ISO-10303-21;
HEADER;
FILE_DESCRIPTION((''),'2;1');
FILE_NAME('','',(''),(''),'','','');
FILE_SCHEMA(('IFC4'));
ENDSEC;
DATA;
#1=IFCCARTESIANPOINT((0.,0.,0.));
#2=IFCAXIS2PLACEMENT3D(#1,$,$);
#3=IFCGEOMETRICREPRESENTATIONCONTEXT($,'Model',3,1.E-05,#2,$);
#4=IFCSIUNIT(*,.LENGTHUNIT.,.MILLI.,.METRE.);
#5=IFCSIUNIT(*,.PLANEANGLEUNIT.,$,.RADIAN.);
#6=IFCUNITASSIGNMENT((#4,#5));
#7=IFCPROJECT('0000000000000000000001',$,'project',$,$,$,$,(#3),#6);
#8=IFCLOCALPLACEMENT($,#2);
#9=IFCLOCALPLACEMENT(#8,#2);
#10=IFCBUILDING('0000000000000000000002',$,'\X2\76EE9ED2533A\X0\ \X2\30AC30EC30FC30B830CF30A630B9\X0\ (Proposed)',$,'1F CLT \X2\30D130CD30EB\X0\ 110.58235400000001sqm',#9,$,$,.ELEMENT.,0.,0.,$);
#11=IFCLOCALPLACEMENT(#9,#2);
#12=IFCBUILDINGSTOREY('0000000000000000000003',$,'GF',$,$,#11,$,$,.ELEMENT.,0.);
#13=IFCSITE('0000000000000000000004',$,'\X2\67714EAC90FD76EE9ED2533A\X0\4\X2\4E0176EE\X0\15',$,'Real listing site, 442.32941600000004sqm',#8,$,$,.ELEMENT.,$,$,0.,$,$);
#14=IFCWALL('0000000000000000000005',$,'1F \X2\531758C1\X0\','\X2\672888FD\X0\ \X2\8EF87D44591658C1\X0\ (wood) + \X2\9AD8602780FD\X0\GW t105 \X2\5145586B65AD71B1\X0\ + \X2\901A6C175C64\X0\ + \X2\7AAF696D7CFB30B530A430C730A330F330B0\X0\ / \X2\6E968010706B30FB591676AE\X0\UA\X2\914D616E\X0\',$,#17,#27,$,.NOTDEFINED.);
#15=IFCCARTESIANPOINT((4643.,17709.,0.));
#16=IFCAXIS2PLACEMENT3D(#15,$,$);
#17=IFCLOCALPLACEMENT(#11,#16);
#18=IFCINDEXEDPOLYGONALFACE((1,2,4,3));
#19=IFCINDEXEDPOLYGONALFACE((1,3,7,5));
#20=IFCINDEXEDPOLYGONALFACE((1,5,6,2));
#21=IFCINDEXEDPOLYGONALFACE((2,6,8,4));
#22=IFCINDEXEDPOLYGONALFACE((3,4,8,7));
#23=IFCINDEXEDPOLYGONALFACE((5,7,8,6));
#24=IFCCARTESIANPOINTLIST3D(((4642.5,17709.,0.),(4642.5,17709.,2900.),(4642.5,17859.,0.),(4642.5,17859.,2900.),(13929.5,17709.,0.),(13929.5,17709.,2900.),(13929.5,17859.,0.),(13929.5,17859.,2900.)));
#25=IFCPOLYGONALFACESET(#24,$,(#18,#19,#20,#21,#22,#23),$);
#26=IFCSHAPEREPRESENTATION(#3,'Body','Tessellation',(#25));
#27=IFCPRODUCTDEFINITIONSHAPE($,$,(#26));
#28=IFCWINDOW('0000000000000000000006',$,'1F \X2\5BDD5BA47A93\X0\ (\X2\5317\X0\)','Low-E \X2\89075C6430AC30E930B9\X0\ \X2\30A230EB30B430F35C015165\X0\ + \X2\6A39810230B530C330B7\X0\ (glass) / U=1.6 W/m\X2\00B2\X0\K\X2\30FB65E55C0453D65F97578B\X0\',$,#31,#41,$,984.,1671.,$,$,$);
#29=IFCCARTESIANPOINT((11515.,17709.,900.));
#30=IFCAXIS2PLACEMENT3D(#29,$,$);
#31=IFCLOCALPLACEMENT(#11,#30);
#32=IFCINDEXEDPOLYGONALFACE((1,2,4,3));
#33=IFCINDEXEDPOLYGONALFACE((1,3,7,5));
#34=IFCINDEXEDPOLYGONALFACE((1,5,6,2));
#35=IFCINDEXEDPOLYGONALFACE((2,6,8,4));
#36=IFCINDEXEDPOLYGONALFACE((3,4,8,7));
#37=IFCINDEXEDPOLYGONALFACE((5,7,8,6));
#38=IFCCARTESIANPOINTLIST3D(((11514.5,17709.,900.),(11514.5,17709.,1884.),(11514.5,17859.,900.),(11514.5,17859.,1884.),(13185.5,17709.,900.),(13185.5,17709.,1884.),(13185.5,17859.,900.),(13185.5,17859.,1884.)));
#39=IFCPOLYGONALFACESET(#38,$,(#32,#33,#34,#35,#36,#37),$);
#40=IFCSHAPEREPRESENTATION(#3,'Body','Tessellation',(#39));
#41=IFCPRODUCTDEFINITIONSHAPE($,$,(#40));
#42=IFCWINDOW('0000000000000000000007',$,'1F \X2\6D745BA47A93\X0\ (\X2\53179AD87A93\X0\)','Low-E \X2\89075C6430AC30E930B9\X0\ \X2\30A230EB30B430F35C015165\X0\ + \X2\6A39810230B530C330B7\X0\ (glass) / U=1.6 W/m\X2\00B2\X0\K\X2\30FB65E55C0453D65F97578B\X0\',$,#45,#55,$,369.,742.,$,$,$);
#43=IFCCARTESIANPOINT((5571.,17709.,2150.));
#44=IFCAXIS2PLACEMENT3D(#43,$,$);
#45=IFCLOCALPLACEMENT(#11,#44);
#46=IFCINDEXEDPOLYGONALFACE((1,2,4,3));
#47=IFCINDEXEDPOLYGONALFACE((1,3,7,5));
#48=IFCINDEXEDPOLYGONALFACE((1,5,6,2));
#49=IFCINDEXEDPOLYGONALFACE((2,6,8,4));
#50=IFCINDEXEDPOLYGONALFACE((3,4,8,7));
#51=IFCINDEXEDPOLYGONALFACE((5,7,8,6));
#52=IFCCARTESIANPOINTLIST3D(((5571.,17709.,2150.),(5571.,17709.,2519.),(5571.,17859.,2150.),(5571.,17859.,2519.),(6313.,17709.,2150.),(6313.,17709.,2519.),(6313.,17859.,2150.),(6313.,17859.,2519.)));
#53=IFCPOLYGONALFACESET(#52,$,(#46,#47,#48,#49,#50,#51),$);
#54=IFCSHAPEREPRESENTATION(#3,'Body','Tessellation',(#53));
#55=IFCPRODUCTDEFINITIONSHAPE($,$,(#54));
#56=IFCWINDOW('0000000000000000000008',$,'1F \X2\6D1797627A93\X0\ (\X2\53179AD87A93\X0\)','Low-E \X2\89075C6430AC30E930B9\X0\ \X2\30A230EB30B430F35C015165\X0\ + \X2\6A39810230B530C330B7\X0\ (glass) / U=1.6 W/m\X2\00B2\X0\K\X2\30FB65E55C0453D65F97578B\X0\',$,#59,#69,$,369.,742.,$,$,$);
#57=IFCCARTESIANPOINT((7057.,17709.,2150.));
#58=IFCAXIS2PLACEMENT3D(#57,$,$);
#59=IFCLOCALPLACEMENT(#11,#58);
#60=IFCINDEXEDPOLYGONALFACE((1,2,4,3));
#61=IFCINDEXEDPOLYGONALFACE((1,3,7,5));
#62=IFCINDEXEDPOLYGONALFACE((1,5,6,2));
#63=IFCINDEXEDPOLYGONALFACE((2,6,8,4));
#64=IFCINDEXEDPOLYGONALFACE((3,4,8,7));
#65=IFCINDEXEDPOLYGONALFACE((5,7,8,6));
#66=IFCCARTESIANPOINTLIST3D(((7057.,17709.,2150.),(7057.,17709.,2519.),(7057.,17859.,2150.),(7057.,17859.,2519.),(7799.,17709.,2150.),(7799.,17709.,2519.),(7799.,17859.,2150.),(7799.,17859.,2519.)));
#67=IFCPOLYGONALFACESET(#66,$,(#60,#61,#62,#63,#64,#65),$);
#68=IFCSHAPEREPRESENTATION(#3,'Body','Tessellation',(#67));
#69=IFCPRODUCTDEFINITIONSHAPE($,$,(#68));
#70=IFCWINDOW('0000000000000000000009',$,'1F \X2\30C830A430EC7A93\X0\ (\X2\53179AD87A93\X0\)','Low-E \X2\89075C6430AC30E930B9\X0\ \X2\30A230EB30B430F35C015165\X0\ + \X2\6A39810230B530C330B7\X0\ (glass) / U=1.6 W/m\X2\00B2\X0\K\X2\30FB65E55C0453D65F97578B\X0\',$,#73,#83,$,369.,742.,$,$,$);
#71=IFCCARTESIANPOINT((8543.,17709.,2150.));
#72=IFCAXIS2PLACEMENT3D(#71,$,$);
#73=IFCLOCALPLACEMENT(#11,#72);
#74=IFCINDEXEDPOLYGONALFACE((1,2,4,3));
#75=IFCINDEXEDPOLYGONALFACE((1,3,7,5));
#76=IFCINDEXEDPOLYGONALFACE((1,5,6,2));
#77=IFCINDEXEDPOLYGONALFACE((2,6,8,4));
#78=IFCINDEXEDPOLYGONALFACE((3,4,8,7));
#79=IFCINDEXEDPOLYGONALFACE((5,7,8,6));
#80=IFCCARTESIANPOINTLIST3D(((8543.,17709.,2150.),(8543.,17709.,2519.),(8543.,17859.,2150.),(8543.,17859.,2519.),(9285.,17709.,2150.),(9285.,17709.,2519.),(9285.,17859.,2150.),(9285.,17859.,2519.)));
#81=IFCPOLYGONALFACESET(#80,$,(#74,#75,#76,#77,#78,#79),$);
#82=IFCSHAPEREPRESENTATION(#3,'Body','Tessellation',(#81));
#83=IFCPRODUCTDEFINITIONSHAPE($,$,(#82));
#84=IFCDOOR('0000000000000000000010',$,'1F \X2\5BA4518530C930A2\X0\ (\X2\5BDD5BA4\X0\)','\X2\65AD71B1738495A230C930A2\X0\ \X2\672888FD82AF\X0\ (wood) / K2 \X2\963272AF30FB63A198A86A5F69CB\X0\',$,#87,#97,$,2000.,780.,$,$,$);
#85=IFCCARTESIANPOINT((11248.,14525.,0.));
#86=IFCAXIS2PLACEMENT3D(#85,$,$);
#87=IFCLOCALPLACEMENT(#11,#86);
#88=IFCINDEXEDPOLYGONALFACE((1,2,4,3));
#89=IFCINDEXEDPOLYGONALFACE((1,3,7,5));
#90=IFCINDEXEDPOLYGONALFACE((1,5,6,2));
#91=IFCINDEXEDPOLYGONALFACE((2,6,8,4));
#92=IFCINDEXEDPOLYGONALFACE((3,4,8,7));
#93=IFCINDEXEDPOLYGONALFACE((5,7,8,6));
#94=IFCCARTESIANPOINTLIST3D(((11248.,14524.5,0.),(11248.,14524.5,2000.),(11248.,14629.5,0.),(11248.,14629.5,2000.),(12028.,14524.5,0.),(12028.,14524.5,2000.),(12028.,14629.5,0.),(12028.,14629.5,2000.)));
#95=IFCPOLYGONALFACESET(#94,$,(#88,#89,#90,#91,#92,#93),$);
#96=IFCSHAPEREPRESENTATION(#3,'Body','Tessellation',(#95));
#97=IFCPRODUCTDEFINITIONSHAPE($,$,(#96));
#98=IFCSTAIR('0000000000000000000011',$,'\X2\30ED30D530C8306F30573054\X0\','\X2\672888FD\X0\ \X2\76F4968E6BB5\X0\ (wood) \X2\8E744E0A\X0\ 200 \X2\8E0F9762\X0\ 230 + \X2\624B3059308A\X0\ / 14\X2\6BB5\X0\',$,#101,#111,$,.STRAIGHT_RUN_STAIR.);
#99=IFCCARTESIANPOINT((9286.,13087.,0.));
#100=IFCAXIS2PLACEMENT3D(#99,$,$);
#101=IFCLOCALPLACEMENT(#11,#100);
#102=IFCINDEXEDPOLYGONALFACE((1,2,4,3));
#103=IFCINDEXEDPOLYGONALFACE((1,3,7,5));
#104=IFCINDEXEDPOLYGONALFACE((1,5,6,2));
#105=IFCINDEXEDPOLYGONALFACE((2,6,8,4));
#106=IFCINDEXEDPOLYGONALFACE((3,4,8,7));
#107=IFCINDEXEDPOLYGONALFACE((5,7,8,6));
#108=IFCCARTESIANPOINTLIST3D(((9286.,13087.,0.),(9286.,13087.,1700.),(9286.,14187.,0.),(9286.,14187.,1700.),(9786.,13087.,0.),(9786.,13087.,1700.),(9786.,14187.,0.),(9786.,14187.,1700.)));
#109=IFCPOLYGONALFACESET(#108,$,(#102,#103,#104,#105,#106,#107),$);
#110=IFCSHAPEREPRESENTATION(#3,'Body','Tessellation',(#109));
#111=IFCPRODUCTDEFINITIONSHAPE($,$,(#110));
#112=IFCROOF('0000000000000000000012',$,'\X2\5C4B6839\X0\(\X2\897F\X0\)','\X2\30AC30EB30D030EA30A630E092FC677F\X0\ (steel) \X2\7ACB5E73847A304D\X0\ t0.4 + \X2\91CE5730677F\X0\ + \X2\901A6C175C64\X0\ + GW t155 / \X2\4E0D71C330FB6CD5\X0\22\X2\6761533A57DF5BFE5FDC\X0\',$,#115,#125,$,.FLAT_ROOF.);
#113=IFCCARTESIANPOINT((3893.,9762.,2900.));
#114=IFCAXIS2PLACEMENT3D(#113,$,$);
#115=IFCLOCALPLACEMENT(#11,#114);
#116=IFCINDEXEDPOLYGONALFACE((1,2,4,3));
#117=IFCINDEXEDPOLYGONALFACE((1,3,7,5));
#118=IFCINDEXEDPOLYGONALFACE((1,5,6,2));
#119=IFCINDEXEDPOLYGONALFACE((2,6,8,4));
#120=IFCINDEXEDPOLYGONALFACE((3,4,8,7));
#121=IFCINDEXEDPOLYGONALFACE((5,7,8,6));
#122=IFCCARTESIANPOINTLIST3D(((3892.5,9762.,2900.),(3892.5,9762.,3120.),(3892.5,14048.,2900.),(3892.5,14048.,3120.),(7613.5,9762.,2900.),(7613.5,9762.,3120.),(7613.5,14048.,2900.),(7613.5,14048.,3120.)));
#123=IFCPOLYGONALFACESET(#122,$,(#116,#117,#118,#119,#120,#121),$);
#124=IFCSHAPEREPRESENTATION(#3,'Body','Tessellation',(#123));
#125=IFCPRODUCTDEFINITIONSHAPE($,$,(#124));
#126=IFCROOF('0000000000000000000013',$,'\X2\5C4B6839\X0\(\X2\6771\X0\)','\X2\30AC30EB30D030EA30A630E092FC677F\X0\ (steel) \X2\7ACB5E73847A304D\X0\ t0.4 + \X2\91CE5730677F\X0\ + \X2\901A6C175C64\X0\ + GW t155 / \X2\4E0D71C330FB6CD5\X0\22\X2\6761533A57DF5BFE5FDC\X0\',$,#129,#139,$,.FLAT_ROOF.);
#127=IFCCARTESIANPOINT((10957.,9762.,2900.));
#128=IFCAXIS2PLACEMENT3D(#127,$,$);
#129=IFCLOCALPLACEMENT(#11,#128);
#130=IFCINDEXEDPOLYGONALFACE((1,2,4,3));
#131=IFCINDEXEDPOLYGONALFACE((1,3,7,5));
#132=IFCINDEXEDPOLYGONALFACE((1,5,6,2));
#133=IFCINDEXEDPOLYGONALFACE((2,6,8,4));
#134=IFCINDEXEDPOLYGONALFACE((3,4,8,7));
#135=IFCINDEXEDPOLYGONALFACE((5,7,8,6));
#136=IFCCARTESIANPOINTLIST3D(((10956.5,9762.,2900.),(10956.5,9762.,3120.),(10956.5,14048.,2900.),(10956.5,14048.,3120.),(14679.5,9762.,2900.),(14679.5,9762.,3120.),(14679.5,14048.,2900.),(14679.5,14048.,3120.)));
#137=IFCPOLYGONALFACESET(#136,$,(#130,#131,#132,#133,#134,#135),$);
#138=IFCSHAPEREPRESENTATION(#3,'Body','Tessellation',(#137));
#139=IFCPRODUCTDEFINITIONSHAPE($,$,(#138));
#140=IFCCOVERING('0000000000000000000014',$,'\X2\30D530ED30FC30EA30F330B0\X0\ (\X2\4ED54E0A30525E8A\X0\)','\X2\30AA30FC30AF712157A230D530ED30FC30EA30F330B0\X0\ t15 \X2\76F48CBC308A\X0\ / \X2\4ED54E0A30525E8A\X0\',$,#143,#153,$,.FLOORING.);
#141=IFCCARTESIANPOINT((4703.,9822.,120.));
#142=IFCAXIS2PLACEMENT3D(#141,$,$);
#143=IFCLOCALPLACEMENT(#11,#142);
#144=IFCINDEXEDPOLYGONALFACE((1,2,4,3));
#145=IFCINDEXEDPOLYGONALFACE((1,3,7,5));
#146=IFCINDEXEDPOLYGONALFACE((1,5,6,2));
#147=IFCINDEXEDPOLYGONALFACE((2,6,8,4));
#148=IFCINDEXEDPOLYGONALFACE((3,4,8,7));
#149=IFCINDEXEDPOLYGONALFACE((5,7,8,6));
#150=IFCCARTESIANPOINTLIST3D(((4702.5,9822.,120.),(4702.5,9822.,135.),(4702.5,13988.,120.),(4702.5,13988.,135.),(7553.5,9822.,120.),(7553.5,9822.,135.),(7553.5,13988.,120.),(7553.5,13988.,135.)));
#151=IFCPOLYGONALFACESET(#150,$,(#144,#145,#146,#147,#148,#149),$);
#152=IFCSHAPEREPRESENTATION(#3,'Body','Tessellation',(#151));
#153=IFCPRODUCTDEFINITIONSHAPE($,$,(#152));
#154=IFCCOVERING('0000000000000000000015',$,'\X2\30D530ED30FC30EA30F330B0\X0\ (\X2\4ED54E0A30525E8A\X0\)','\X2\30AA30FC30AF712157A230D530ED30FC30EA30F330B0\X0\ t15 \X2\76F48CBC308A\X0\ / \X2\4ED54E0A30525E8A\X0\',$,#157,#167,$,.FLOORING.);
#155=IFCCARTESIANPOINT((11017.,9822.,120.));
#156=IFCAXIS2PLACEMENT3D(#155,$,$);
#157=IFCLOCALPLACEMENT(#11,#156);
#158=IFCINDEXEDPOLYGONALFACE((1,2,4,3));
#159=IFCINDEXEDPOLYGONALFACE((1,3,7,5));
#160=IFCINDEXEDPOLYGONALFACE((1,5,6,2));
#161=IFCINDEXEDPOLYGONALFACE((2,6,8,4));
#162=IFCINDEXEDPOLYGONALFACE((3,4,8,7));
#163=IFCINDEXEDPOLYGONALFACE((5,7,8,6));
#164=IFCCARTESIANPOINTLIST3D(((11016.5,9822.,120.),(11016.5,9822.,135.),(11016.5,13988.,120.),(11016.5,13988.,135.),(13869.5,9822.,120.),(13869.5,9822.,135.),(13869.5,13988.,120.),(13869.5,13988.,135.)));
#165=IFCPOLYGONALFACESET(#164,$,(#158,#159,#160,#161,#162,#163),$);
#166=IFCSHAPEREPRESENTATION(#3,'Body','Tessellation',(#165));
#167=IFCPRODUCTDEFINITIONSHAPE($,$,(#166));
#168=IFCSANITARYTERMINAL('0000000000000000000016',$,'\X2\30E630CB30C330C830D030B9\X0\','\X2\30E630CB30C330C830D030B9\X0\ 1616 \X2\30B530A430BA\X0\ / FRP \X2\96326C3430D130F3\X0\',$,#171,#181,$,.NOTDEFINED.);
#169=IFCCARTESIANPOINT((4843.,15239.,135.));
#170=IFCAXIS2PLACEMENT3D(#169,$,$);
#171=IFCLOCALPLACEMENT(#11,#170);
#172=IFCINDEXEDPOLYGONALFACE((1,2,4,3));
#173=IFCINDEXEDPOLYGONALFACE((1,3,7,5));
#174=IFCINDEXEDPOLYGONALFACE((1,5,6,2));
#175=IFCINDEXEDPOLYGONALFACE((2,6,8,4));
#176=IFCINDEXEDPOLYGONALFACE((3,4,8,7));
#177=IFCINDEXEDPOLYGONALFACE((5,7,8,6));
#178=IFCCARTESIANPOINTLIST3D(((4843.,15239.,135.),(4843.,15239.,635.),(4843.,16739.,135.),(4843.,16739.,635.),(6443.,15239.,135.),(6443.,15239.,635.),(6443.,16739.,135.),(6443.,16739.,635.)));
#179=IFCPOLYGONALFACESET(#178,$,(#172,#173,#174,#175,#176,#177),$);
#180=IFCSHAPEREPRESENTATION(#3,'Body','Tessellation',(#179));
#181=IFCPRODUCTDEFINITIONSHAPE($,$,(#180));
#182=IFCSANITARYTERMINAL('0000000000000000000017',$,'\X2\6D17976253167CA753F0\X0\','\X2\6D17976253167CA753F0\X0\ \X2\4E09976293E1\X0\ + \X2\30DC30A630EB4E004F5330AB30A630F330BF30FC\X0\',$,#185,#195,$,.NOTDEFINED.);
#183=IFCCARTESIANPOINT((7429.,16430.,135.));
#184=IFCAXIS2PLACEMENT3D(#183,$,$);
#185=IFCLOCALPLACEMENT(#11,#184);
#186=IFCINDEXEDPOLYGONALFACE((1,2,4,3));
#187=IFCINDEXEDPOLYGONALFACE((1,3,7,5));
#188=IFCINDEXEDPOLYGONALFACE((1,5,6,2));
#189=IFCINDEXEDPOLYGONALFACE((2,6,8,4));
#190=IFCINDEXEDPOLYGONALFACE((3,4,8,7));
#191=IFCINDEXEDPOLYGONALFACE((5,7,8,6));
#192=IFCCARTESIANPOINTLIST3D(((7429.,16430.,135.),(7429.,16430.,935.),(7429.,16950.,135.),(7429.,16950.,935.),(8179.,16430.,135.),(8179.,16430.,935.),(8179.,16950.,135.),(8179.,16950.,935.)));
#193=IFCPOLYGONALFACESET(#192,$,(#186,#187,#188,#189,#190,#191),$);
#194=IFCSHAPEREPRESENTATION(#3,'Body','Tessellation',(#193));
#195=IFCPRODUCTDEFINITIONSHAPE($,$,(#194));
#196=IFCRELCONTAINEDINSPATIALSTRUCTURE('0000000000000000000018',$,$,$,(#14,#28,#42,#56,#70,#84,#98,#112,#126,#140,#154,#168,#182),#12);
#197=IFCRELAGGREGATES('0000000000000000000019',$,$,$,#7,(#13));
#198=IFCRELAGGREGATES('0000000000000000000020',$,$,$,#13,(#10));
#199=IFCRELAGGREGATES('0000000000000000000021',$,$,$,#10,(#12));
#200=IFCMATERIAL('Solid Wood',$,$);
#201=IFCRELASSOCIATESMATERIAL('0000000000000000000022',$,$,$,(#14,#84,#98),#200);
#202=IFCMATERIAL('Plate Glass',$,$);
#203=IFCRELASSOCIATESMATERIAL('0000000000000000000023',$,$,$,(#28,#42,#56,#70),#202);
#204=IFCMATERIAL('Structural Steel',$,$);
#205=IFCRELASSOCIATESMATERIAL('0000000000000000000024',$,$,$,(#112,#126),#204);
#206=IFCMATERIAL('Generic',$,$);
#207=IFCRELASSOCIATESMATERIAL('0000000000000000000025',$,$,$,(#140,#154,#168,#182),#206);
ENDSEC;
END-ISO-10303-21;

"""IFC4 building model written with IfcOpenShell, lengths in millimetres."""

from ifc_helpers import new_model, si_unit, frame, frame_2d, origin, place, context, project, spatial, rectangle, extrude, material, element, fill, save


model = new_model("IFC4")

# Units and contexts
model_context = context("Model", 3, precision=1e-05, world=origin())
ifc_project = project(units=[si_unit("LENGTHUNIT", "METRE", prefix="MILLI"), si_unit("PLANEANGLEUNIT", "RADIAN")], contexts=[model_context])

# Site, building, storey
site_placement = place(None, origin())
site = spatial("IfcSite", under=ifc_project, at=site_placement, Name="東京都目黒区4丁目15", ObjectType="Real listing site, 442.32941600000004sqm", CompositionType="ELEMENT", RefElevation=0.0)
building_placement = place(site_placement, origin())
building = spatial("IfcBuilding", under=site, at=building_placement, Name="目黒区 ガレージハウス (Proposed)", ObjectType="1F CLT パネル 110.58235400000001sqm", CompositionType="ELEMENT", ElevationOfRefHeight=0.0, ElevationOfTerrain=0.0)
storey_placement = place(building_placement, origin())
storey = spatial("IfcBuildingStorey", under=building, at=storey_placement, Name="GF", CompositionType="ELEMENT", Elevation=0.0)

# Shared definitions
ifc_material_1 = material(Name="Solid Wood")

# Wall, openings, windows
wall_1_placement = place(storey_placement, frame((4643.0, 17709.0, 0.0)))
wall_1 = element("IfcWall", 1, at=wall_1_placement, inside=storey, material=ifc_material_1, Name="1F 北壁", Description="木製 軸組外壁 (wood) + 高性能GW t105 充填断熱 + 通気層 + 窯業系サイディング / 準耐火・外皮UA配慮", PredefinedType="NOTDEFINED", context=model_context, shape_type="SweptSolid", body=[
    extrude(rectangle(XDim=9287.0, YDim=150.0, at=frame_2d((4643.0, 75.0))), frame((4643.0, 17709.0, 0.0)), (0.0, 0.0, 1.0), 2900.0),
])
opening_1_placement = place(storey_placement, frame((11515.0, 17709.0, 900.0)))
opening_1 = element("IfcOpeningElement", 2, at=opening_1_placement, cuts=wall_1, PredefinedType="NOTDEFINED", context=model_context, shape_type="SweptSolid", body=[
    extrude(rectangle(XDim=1671.0, YDim=150.0, at=frame_2d((835.0, 75.0))), frame((11515.0, 17709.0, 900.0)), (0.0, 0.0, 1.0), 984.0),
])
opening_2_placement = place(storey_placement, frame((5571.0, 17709.0, 2150.0)))
opening_2 = element("IfcOpeningElement", 3, at=opening_2_placement, cuts=wall_1, PredefinedType="NOTDEFINED", context=model_context, shape_type="SweptSolid", body=[
    extrude(rectangle(XDim=742.0, YDim=150.0, at=frame_2d((371.0, 75.0))), frame((5571.0, 17709.0, 2150.0)), (0.0, 0.0, 1.0), 369.0),
])
opening_3_placement = place(storey_placement, frame((7057.0, 17709.0, 2150.0)))
opening_3 = element("IfcOpeningElement", 4, at=opening_3_placement, cuts=wall_1, PredefinedType="NOTDEFINED", context=model_context, shape_type="SweptSolid", body=[
    extrude(rectangle(XDim=742.0, YDim=150.0, at=frame_2d((371.0, 75.0))), frame((7057.0, 17709.0, 2150.0)), (0.0, 0.0, 1.0), 369.0),
])
opening_4_placement = place(storey_placement, frame((8543.0, 17709.0, 2150.0)))
opening_4 = element("IfcOpeningElement", 5, at=opening_4_placement, cuts=wall_1, PredefinedType="NOTDEFINED", context=model_context, shape_type="SweptSolid", body=[
    extrude(rectangle(XDim=742.0, YDim=150.0, at=frame_2d((371.0, 75.0))), frame((8543.0, 17709.0, 2150.0)), (0.0, 0.0, 1.0), 369.0),
])
ifc_material_2 = material(Name="Plate Glass")
window_1_placement = place(storey_placement, frame((11515.0, 17709.0, 900.0)))
window_1 = element("IfcWindow", 6, at=window_1_placement, inside=storey, material=ifc_material_2, Name="1F 寝室窓 (北)", Description="Low-E 複層ガラス アルゴン封入 + 樹脂サッシ (glass) / U=1.6 W/m²K・日射取得型", OverallHeight=984.0, OverallWidth=1671.0, context=model_context, shape_type="SweptSolid", body=[
    extrude(rectangle(XDim=1671.0, YDim=150.0, at=frame_2d((835.0, 75.0))), frame((11515.0, 17709.0, 900.0)), (0.0, 0.0, 1.0), 984.0),
])
fill(opening_1, window_1)
window_2_placement = place(storey_placement, frame((5571.0, 17709.0, 2150.0)))
window_2 = element("IfcWindow", 7, at=window_2_placement, inside=storey, material=ifc_material_2, Name="1F 浴室窓 (北高窓)", Description="Low-E 複層ガラス アルゴン封入 + 樹脂サッシ (glass) / U=1.6 W/m²K・日射取得型", OverallHeight=369.0, OverallWidth=742.0, context=model_context, shape_type="SweptSolid", body=[
    extrude(rectangle(XDim=742.0, YDim=150.0, at=frame_2d((371.0, 75.0))), frame((5571.0, 17709.0, 2150.0)), (0.0, 0.0, 1.0), 369.0),
])
fill(opening_2, window_2)
window_3_placement = place(storey_placement, frame((7057.0, 17709.0, 2150.0)))
window_3 = element("IfcWindow", 8, at=window_3_placement, inside=storey, material=ifc_material_2, Name="1F 洗面窓 (北高窓)", Description="Low-E 複層ガラス アルゴン封入 + 樹脂サッシ (glass) / U=1.6 W/m²K・日射取得型", OverallHeight=369.0, OverallWidth=742.0, context=model_context, shape_type="SweptSolid", body=[
    extrude(rectangle(XDim=742.0, YDim=150.0, at=frame_2d((371.0, 75.0))), frame((7057.0, 17709.0, 2150.0)), (0.0, 0.0, 1.0), 369.0),
])
fill(opening_3, window_3)
window_4_placement = place(storey_placement, frame((8543.0, 17709.0, 2150.0)))
window_4 = element("IfcWindow", 9, at=window_4_placement, inside=storey, material=ifc_material_2, Name="1F トイレ窓 (北高窓)", Description="Low-E 複層ガラス アルゴン封入 + 樹脂サッシ (glass) / U=1.6 W/m²K・日射取得型", OverallHeight=369.0, OverallWidth=742.0, context=model_context, shape_type="SweptSolid", body=[
    extrude(rectangle(XDim=742.0, YDim=150.0, at=frame_2d((371.0, 75.0))), frame((8543.0, 17709.0, 2150.0)), (0.0, 0.0, 1.0), 369.0),
])
fill(opening_4, window_4)

# Door
door_1_placement = place(storey_placement, frame((11248.0, 14525.0, 0.0)))
element("IfcDoor", 10, at=door_1_placement, inside=storey, material=ifc_material_1, Name="1F 室内ドア (寝室)", Description="断熱玄関ドア 木製芯 (wood) / K2 防犯・採風機構", OverallHeight=2000.0, OverallWidth=780.0, context=model_context, shape_type="SweptSolid", body=[
    extrude(rectangle(XDim=780.0, YDim=105.0, at=frame_2d((390.0, 52.0))), frame((11248.0, 14525.0, 0.0)), (0.0, 0.0, 1.0), 2000.0),
])

# Stair
stair_placement = place(storey_placement, frame((9286.0, 13087.0, 0.0)))
element("IfcStair", 11, at=stair_placement, inside=storey, material=ifc_material_1, Name="ロフトはしご", Description="木製 直階段 (wood) 蹴上 200 踏面 230 + 手すり / 14段", PredefinedType="STRAIGHT_RUN_STAIR", context=model_context, shape_type="SweptSolid", body=[
    extrude(rectangle(XDim=500.0, YDim=1100.0, at=frame_2d((250.0, 550.0))), frame((9286.0, 13087.0, 0.0)), (0.0, 0.0, 1.0), 1700.0),
])

# Roofs
ifc_material_3 = material(Name="Structural Steel")
roof_1_placement = place(storey_placement, frame((3893.0, 9762.0, 2900.0)))
element("IfcRoof", 12, at=roof_1_placement, inside=storey, material=ifc_material_3, Name="屋根(西)", Description="ガルバリウム鋼板 (steel) 立平葺き t0.4 + 野地板 + 通気層 + GW t155 / 不燃・法22条区域対応", PredefinedType="FLAT_ROOF", context=model_context, shape_type="SweptSolid", body=[
    extrude(rectangle(XDim=3721.0, YDim=4286.0, at=frame_2d((1860.0, 2143.0))), frame((3893.0, 9762.0, 2900.0)), (0.0, 0.0, 1.0), 220.0),
])
roof_2_placement = place(storey_placement, frame((10957.0, 9762.0, 2900.0)))
element("IfcRoof", 13, at=roof_2_placement, inside=storey, material=ifc_material_3, Name="屋根(東)", Description="ガルバリウム鋼板 (steel) 立平葺き t0.4 + 野地板 + 通気層 + GW t155 / 不燃・法22条区域対応", PredefinedType="FLAT_ROOF", context=model_context, shape_type="SweptSolid", body=[
    extrude(rectangle(XDim=3723.0, YDim=4286.0, at=frame_2d((1861.0, 2143.0))), frame((10957.0, 9762.0, 2900.0)), (0.0, 0.0, 1.0), 220.0),
])

# Coverings
ifc_material_4 = material(Name="Generic")
covering_1_placement = place(storey_placement, frame((4703.0, 9822.0, 120.0)))
element("IfcCovering", 14, at=covering_1_placement, inside=storey, material=ifc_material_4, Name="フローリング (仕上げ床)", Description="オーク無垢フローリング t15 直貼り / 仕上げ床", PredefinedType="FLOORING", context=model_context, shape_type="SweptSolid", body=[
    extrude(rectangle(XDim=2851.0, YDim=4166.0, at=frame_2d((1425.0, 2083.0))), frame((4703.0, 9822.0, 120.0)), (0.0, 0.0, 1.0), 15.0),
])
covering_2_placement = place(storey_placement, frame((11017.0, 9822.0, 120.0)))
element("IfcCovering", 15, at=covering_2_placement, inside=storey, material=ifc_material_4, Name="フローリング (仕上げ床)", Description="オーク無垢フローリング t15 直貼り / 仕上げ床", PredefinedType="FLOORING", context=model_context, shape_type="SweptSolid", body=[
    extrude(rectangle(XDim=2853.0, YDim=4166.0, at=frame_2d((1426.0, 2083.0))), frame((11017.0, 9822.0, 120.0)), (0.0, 0.0, 1.0), 15.0),
])

# Sanitary terminals
sanitary_terminal_1_placement = place(storey_placement, frame((4843.0, 15239.0, 135.0)))
element("IfcSanitaryTerminal", 16, at=sanitary_terminal_1_placement, inside=storey, material=ifc_material_4, Name="ユニットバス", Description="ユニットバス 1616 サイズ / FRP 防水パン", PredefinedType="NOTDEFINED", context=model_context, shape_type="SweptSolid", body=[
    extrude(rectangle(XDim=1600.0, YDim=1500.0, at=frame_2d((800.0, 750.0))), frame((4843.0, 15239.0, 135.0)), (0.0, 0.0, 1.0), 500.0),
])
sanitary_terminal_2_placement = place(storey_placement, frame((7429.0, 16430.0, 135.0)))
element("IfcSanitaryTerminal", 17, at=sanitary_terminal_2_placement, inside=storey, material=ifc_material_4, Name="洗面化粧台", Description="洗面化粧台 三面鏡 + ボウル一体カウンター", PredefinedType="NOTDEFINED", context=model_context, shape_type="SweptSolid", body=[
    extrude(rectangle(XDim=750.0, YDim=520.0, at=frame_2d((375.0, 260.0))), frame((7429.0, 16430.0, 135.0)), (0.0, 0.0, 1.0), 800.0),
])

save(model, "model.ifc")
